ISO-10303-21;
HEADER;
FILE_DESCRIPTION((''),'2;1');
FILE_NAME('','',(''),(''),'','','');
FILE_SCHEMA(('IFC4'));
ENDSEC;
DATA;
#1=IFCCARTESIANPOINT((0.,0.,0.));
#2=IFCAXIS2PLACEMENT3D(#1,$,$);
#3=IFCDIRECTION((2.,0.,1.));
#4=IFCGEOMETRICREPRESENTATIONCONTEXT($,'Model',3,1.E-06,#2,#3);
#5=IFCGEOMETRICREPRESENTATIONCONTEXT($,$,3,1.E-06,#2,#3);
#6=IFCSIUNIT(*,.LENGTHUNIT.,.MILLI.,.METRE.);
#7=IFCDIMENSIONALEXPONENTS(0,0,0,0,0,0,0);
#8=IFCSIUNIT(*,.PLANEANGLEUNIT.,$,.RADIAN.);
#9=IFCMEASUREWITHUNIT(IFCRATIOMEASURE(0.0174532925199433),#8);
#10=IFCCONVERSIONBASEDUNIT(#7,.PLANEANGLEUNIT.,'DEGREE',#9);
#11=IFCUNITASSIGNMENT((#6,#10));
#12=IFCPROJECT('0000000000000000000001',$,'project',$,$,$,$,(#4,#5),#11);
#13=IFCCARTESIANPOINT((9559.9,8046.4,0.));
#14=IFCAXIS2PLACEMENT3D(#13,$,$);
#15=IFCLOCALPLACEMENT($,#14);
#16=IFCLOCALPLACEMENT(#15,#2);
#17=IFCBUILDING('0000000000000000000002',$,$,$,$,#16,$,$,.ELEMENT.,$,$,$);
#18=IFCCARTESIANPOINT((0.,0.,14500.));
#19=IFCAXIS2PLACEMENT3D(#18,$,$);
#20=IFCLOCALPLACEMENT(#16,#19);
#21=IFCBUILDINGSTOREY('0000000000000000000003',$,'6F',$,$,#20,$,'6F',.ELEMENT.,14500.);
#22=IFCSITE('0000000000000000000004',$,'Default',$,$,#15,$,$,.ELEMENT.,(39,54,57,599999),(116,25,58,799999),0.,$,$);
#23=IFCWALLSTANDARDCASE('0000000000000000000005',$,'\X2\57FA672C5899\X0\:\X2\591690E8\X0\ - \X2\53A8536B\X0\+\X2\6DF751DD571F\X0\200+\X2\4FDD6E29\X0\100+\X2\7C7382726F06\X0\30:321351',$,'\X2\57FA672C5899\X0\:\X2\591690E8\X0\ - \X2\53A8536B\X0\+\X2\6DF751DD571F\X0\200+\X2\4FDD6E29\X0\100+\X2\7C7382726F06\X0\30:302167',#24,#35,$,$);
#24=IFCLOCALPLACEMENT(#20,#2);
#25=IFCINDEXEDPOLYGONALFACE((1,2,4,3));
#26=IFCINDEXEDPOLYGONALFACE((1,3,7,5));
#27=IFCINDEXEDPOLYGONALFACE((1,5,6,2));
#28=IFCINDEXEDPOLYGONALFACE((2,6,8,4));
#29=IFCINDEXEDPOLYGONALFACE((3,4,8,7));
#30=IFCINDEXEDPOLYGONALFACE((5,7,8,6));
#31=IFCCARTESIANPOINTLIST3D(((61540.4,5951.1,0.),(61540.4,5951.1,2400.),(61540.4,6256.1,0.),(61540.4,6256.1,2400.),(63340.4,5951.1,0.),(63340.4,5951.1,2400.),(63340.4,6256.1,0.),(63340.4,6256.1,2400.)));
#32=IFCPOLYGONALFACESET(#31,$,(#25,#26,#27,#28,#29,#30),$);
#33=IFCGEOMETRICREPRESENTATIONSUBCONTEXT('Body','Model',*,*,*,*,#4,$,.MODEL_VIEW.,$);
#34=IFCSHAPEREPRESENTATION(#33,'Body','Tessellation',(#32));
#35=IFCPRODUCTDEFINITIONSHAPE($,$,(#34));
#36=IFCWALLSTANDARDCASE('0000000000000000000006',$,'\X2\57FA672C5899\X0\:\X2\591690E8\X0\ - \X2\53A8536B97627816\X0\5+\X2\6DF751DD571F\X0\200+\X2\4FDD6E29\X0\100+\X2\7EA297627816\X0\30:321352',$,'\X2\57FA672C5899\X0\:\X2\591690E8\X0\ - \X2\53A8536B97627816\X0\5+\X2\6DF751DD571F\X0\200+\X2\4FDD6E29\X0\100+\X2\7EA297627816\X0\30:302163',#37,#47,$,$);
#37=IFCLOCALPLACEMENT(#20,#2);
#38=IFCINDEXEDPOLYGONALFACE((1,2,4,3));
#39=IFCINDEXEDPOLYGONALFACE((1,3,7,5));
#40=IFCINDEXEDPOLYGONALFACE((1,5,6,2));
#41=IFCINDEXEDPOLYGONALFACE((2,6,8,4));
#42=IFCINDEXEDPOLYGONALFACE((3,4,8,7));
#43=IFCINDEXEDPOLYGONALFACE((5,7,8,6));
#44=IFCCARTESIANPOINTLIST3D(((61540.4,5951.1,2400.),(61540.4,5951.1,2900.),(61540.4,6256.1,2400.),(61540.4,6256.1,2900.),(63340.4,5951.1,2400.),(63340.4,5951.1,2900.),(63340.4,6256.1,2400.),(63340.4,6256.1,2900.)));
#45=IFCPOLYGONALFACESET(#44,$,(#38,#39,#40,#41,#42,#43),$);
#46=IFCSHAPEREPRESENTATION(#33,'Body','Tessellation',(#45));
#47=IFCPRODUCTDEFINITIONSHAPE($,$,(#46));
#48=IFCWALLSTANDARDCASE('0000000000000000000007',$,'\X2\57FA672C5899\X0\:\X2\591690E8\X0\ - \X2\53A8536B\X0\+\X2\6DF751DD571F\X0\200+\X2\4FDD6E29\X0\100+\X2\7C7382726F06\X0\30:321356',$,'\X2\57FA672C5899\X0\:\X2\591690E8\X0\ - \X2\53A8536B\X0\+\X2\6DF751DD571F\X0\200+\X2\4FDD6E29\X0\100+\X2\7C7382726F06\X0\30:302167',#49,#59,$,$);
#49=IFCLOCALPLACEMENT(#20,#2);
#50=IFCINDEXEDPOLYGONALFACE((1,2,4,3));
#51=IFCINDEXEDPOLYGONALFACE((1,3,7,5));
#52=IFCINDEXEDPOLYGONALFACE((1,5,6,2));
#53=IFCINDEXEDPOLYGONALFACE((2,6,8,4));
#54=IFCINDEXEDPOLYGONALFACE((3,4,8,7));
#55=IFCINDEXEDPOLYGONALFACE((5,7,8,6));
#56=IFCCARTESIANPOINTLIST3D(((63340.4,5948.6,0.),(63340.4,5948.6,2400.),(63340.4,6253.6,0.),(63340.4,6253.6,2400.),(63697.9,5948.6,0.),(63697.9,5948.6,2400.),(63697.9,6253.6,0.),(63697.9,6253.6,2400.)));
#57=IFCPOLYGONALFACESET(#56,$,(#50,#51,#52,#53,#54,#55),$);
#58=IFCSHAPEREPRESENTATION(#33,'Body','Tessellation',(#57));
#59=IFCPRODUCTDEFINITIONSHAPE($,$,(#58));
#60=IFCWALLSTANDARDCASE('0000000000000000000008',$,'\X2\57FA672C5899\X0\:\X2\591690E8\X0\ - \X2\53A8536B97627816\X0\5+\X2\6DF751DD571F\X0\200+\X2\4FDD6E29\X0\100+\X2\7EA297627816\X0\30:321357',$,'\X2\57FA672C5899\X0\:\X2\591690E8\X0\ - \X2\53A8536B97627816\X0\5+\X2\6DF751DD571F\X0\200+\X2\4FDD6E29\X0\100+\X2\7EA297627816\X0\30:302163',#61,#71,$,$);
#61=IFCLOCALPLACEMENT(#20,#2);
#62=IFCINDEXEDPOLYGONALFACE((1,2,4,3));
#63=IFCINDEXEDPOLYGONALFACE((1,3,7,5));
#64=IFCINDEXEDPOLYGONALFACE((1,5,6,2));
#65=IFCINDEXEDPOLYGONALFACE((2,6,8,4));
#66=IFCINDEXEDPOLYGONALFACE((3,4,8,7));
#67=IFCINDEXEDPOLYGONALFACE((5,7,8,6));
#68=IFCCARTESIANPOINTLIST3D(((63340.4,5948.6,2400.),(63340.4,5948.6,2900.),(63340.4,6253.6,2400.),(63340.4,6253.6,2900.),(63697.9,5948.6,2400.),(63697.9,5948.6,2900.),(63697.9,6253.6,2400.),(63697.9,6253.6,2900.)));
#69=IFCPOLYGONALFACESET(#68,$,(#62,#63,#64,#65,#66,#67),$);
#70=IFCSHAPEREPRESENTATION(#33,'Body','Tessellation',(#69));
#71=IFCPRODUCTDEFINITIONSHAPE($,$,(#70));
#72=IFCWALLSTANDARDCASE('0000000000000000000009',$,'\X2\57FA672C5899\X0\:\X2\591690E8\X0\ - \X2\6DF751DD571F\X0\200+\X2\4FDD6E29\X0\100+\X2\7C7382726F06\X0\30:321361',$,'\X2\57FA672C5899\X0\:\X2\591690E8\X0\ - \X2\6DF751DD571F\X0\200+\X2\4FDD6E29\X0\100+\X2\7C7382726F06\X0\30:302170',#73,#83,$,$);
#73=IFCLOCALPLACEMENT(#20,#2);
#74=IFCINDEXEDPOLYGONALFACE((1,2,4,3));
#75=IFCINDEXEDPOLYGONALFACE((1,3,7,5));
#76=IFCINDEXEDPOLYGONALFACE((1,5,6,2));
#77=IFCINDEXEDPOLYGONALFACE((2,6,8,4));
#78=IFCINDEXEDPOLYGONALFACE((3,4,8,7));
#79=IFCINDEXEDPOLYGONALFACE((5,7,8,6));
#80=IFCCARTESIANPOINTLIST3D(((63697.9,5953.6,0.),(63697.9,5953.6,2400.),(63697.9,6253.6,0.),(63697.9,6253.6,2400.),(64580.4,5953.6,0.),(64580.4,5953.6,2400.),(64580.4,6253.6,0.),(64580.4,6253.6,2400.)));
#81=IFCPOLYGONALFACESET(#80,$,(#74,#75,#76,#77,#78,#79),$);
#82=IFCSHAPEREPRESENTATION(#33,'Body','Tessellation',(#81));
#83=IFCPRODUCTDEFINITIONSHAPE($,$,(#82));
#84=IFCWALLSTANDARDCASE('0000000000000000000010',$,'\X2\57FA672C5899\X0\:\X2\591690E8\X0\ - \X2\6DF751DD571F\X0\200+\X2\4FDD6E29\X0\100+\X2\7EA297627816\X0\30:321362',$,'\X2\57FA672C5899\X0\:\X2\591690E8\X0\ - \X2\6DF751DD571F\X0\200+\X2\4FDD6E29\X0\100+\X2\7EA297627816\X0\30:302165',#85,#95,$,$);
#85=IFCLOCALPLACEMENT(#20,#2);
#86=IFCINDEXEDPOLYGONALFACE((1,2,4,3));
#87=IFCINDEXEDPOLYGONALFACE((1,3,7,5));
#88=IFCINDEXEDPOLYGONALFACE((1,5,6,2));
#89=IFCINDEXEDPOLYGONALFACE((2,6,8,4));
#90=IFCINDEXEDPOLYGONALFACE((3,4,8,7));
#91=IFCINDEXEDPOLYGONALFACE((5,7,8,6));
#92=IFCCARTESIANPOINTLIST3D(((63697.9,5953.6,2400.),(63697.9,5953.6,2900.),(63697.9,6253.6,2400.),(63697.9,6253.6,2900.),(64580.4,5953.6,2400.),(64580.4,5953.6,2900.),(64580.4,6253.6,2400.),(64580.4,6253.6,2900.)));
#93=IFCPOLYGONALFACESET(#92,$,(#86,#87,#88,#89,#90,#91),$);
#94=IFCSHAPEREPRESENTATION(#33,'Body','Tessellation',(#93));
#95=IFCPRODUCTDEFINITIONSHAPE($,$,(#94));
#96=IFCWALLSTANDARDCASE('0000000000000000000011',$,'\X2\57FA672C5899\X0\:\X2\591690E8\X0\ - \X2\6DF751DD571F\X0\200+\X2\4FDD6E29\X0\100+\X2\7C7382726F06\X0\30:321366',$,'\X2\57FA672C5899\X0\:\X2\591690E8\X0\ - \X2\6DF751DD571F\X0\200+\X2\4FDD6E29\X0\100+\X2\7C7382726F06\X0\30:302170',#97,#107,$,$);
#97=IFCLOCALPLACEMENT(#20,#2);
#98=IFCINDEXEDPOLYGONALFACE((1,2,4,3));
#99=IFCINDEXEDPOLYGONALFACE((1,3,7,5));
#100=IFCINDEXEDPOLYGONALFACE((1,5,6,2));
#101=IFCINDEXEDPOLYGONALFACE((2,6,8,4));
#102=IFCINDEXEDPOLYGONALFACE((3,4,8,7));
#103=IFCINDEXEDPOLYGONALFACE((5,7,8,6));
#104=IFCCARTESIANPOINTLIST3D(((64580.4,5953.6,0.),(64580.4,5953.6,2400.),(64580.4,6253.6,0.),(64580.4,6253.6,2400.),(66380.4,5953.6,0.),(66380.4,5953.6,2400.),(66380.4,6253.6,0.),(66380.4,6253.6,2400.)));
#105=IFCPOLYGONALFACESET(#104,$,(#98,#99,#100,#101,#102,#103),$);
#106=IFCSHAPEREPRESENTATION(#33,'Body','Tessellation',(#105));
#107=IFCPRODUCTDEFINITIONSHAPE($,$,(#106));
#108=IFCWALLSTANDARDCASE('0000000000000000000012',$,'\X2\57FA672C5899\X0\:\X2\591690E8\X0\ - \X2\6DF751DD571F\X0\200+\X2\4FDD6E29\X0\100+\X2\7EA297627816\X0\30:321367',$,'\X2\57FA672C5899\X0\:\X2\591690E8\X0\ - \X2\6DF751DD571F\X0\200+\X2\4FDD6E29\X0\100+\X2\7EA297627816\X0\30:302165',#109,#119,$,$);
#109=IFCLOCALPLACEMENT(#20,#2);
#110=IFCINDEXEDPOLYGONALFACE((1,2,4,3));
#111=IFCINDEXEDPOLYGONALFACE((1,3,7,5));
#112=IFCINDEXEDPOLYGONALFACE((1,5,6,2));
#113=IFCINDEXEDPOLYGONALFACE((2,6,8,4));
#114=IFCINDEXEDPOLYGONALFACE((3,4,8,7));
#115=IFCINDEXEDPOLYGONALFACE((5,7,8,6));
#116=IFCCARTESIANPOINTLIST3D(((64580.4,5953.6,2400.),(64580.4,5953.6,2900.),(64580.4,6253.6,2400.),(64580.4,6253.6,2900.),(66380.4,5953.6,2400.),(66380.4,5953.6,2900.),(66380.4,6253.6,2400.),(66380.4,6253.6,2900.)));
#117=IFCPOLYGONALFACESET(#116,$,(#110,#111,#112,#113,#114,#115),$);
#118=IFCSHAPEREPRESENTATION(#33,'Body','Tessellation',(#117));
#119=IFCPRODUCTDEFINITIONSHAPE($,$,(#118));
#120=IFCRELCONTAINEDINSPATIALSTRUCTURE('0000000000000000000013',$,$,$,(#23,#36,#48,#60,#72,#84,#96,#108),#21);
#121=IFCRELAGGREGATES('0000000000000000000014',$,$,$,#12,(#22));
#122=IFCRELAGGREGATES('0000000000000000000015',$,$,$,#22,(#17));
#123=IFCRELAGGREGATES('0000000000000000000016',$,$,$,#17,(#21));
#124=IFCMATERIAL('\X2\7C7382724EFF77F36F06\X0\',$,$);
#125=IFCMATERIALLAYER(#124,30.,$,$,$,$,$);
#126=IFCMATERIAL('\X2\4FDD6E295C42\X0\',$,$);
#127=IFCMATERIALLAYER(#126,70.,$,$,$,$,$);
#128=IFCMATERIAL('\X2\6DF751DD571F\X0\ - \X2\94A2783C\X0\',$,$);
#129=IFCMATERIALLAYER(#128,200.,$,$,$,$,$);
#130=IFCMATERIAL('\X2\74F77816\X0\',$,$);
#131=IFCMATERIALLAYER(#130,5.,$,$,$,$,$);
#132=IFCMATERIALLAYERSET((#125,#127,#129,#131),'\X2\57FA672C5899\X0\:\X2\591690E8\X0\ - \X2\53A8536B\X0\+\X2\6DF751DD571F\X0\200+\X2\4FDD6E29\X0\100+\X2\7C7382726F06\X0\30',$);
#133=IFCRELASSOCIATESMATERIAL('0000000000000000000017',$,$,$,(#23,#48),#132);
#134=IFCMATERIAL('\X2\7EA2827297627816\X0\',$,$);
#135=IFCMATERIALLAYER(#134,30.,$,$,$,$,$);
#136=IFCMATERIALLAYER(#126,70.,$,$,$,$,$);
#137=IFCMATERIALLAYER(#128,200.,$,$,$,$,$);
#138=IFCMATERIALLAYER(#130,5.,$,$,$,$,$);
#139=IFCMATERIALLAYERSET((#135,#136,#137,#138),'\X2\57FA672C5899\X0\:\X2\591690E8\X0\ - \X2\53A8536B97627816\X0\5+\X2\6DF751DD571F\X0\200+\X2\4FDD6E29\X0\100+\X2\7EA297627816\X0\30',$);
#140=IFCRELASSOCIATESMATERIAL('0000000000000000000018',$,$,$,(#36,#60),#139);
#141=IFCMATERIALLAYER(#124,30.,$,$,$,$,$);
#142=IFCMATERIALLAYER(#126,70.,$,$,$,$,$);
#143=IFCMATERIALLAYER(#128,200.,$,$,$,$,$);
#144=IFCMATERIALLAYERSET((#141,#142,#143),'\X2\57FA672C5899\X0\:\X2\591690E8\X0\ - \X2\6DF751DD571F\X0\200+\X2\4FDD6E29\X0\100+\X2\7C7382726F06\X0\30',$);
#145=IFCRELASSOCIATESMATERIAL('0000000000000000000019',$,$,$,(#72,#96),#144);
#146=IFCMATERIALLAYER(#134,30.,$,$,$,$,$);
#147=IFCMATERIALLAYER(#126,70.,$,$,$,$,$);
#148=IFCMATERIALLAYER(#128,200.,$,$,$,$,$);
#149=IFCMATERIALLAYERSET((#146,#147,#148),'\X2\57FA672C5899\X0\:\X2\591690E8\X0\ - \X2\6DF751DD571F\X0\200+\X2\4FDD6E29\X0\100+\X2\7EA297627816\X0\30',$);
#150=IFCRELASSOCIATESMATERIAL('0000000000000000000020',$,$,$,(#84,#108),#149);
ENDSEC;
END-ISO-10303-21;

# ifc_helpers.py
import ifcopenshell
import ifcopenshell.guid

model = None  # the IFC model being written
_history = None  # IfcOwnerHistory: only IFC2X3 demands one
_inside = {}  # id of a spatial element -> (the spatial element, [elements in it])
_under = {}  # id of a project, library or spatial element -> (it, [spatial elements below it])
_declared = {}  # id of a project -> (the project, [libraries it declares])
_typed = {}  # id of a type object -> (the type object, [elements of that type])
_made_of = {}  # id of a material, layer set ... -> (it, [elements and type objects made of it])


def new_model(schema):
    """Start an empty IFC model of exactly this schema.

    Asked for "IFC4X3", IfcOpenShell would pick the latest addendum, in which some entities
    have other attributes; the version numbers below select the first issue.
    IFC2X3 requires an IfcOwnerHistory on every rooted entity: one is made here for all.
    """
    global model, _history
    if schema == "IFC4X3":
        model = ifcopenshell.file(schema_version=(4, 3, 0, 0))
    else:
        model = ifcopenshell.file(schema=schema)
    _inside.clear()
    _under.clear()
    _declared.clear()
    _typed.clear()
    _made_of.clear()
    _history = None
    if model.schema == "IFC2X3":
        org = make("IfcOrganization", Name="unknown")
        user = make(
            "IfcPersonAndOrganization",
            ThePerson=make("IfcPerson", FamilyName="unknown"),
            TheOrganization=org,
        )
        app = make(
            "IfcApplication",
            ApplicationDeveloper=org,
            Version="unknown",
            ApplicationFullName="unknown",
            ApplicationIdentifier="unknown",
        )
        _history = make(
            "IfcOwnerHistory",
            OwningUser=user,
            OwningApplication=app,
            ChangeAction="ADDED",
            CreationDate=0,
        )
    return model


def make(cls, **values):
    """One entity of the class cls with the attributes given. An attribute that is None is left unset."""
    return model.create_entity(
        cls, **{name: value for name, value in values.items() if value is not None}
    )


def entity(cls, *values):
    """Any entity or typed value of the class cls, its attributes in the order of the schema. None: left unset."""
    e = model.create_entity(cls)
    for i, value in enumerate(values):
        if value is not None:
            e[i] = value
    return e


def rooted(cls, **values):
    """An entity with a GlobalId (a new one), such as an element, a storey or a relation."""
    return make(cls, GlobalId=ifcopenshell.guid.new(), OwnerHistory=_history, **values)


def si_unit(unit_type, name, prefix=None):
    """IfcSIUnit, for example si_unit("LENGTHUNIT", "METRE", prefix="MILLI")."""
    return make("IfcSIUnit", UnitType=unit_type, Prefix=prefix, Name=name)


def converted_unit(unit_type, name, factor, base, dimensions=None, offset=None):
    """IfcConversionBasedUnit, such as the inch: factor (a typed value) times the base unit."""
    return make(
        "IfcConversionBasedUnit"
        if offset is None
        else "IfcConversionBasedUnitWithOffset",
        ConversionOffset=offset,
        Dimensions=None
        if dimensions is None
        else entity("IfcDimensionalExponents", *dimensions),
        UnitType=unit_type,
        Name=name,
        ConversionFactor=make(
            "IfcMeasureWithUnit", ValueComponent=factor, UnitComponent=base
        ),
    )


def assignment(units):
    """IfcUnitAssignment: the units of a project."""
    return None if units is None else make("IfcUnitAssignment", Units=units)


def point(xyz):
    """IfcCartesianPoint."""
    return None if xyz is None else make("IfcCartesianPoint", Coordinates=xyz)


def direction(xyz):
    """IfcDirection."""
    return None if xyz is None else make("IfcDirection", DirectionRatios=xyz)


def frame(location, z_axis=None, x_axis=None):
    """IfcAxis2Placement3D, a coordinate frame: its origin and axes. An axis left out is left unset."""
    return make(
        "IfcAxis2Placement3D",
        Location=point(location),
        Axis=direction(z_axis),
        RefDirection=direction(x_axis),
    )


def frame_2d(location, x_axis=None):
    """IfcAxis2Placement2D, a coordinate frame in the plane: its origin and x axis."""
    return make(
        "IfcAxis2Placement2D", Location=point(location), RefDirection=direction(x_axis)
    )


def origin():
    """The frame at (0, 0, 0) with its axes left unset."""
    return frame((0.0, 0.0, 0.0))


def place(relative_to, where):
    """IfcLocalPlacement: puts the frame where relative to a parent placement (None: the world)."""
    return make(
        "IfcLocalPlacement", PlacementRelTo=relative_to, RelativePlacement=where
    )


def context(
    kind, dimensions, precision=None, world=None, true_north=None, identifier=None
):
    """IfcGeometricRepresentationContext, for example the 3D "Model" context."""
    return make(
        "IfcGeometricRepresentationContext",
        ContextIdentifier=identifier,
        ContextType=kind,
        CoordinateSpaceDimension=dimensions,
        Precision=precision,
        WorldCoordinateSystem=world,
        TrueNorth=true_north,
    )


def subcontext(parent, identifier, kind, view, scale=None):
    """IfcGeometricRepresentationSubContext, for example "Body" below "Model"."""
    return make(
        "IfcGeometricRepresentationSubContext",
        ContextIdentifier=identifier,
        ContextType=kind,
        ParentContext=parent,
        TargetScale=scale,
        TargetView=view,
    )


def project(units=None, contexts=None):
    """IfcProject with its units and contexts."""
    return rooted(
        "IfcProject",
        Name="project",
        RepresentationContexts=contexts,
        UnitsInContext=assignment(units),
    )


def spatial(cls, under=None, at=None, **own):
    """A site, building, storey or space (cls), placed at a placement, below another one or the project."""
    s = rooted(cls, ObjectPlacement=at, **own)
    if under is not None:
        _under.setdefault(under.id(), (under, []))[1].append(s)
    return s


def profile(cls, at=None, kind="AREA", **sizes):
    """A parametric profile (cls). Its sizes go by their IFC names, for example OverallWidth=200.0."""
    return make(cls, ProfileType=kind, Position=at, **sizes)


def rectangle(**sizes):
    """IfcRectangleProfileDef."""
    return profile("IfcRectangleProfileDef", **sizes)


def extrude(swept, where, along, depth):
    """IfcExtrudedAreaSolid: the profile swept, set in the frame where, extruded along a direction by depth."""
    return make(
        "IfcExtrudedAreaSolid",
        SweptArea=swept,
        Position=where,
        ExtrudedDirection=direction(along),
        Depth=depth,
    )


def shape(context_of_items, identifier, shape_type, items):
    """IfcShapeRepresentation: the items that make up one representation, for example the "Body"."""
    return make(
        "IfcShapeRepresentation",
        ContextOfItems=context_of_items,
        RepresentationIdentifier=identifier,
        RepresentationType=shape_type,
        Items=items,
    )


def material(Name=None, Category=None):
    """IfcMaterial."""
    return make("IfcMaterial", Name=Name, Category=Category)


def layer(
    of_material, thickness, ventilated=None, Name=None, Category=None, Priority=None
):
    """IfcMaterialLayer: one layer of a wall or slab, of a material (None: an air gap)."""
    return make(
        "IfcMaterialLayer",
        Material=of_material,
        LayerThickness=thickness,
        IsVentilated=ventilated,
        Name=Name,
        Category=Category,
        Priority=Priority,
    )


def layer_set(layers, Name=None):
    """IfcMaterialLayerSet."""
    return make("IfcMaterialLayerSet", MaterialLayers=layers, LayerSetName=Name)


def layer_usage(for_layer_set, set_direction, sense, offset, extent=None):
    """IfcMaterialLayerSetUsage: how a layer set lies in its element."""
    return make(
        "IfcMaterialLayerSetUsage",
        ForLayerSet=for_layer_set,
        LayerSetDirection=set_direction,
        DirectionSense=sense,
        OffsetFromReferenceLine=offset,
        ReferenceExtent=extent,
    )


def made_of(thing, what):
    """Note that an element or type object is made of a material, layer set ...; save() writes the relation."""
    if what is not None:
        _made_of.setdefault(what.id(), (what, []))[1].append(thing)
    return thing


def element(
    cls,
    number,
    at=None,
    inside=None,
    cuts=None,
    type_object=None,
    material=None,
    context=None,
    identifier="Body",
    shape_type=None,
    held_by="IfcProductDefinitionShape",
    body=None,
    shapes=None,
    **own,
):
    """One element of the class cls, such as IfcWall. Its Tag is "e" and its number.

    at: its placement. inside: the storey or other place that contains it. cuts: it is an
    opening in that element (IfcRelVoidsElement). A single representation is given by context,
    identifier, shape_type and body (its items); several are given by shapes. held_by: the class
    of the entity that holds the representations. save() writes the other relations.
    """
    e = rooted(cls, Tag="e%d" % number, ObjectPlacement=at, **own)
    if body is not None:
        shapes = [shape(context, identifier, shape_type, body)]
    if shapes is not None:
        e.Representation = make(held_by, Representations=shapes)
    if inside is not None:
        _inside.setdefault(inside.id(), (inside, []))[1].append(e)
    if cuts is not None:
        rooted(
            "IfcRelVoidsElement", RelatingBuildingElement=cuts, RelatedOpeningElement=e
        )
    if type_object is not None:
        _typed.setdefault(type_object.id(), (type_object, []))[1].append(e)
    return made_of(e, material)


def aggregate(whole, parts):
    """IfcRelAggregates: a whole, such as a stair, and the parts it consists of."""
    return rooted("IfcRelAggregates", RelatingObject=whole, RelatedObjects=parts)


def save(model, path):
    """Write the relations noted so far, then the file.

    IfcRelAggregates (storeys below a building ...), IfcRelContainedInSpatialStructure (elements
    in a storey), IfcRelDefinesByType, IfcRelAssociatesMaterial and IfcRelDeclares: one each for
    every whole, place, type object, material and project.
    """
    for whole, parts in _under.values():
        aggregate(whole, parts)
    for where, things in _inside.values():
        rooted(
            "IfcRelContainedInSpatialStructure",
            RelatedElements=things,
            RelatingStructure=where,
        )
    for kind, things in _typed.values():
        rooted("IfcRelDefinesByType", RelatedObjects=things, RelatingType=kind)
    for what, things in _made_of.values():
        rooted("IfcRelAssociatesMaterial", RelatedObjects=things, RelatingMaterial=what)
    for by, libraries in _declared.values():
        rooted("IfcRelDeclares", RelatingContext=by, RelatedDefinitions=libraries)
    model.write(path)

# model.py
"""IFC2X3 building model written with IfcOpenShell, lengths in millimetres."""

from ifc_helpers import new_model, entity, si_unit, converted_unit, direction, frame, frame_2d, origin, place, context, subcontext, project, spatial, rectangle, extrude, material, layer, layer_set, layer_usage, element, save


model = new_model("IFC2X3")

# Units and contexts
model_context = context("Model", 3, precision=1e-06, world=origin(), true_north=direction((2.0, 0.0, 1.0)))
context_of_model = context(None, 3, precision=1e-06, world=origin(), true_north=direction((2.0, 0.0, 1.0)))
body_context = subcontext(model_context, "Body", "Model", "MODEL_VIEW")
ifc_project = project(units=[si_unit("LENGTHUNIT", "METRE", prefix="MILLI"), converted_unit("PLANEANGLEUNIT", "DEGREE", entity("IfcRatioMeasure", 0.0174532925199433), si_unit("PLANEANGLEUNIT", "RADIAN"), dimensions=[0, 0, 0, 0, 0, 0, 0])], contexts=[model_context, context_of_model])

# Site, building, storey
site_placement = place(None, frame((9559.9, 8046.4, 0.0)))
site = spatial("IfcSite", under=ifc_project, at=site_placement, Name="Default", CompositionType="ELEMENT", RefLatitude=(39, 54, 57, 599999), RefLongitude=(116, 25, 58, 799999), RefElevation=0.0)
building_placement = place(site_placement, origin())
building = spatial("IfcBuilding", under=site, at=building_placement, CompositionType="ELEMENT")
storey_placement = place(building_placement, frame((0.0, 0.0, 14500.0)))
storey = spatial("IfcBuildingStorey", under=building, at=storey_placement, Name="6F", LongName="6F", CompositionType="ELEMENT", Elevation=14500.0)

# Shared definitions
ifc_material_1 = material(Name="红色面砖")
ifc_layer_1 = layer(ifc_material_1, 30.0)
ifc_material_2 = material(Name="保温层")
ifc_layer_2 = layer(ifc_material_2, 70.0)
ifc_material_3 = material(Name="混凝土 - 钢砼")
ifc_layer_3 = layer(ifc_material_3, 200.0)
ifc_layer_set_1 = layer_set([ifc_layer_1, ifc_layer_2, ifc_layer_3], Name="基本墙:外部 - 混凝土200+保温100+红面砖30")

# Shared definitions
ifc_material_4 = material(Name="瓷砖")

# Shared definitions
ifc_layer_4 = layer(ifc_material_1, 30.0)
ifc_layer_5 = layer(ifc_material_2, 70.0)
ifc_layer_6 = layer(ifc_material_3, 200.0)
ifc_layer_7 = layer(ifc_material_4, 5.0)
ifc_layer_set_2 = layer_set([ifc_layer_4, ifc_layer_5, ifc_layer_6, ifc_layer_7], Name="基本墙:外部 - 厨卫面砖5+混凝土200+保温100+红面砖30")

# Walls
ifc_material_5 = material(Name="米色仿石漆")
ifc_layer_8 = layer(ifc_material_5, 30.0)
ifc_layer_9 = layer(ifc_material_2, 70.0)
ifc_layer_10 = layer(ifc_material_3, 200.0)
ifc_layer_11 = layer(ifc_material_4, 5.0)
ifc_layer_set_3 = layer_set([ifc_layer_8, ifc_layer_9, ifc_layer_10, ifc_layer_11], Name="基本墙:外部 - 厨卫+混凝土200+保温100+米色漆30")
ifc_layer_usage_1 = layer_usage(ifc_layer_set_3, "AXIS2", "POSITIVE", -152.5)
wall_1_placement = place(storey_placement, frame((63340.4, 6103.6, 0.0), z_axis=(0.0, 0.0, 1.0), x_axis=(-1.0, 0.0, 0.0)))
element("IfcWallStandardCase", 1, at=wall_1_placement, inside=storey, material=ifc_layer_usage_1, Name="基本墙:外部 - 厨卫+混凝土200+保温100+米色漆30:321351", ObjectType="基本墙:外部 - 厨卫+混凝土200+保温100+米色漆30:302167", context=body_context, shape_type="SweptSolid", body=[
    extrude(rectangle(XDim=1800.0, YDim=305.0, at=frame_2d((900.0, 0.0), x_axis=(-1.0, 0.0))), origin(), (0.0, 0.0, 1.0), 2400.0),
])
ifc_layer_usage_2 = layer_usage(ifc_layer_set_2, "AXIS2", "POSITIVE", -152.5)
wall_2_placement = place(storey_placement, frame((63340.4, 6103.6, 2400.0), z_axis=(0.0, 0.0, 1.0), x_axis=(-1.0, 0.0, 0.0)))
element("IfcWallStandardCase", 2, at=wall_2_placement, inside=storey, material=ifc_layer_usage_2, Name="基本墙:外部 - 厨卫面砖5+混凝土200+保温100+红面砖30:321352", ObjectType="基本墙:外部 - 厨卫面砖5+混凝土200+保温100+红面砖30:302163", context=body_context, shape_type="SweptSolid", body=[
    extrude(rectangle(XDim=1800.0, YDim=305.0, at=frame_2d((900.0, 0.0), x_axis=(-1.0, 0.0))), origin(), (0.0, 0.0, 1.0), 500.0),
])
ifc_layer_usage_3 = layer_usage(ifc_layer_set_3, "AXIS2", "POSITIVE", -152.5)
wall_3_placement = place(storey_placement, frame((63697.9, 6101.1, 0.0), z_axis=(0.0, 0.0, 1.0), x_axis=(-1.0, 0.0, 0.0)))
element("IfcWallStandardCase", 3, at=wall_3_placement, inside=storey, material=ifc_layer_usage_3, Name="基本墙:外部 - 厨卫+混凝土200+保温100+米色漆30:321356", ObjectType="基本墙:外部 - 厨卫+混凝土200+保温100+米色漆30:302167", context=body_context, shape_type="SweptSolid", body=[
    extrude(rectangle(XDim=357.5, YDim=305.0, at=frame_2d((178.7, 0.0), x_axis=(-1.0, 0.0))), origin(), (0.0, 0.0, 1.0), 2400.0),
])
ifc_layer_usage_4 = layer_usage(ifc_layer_set_2, "AXIS2", "POSITIVE", -152.5)
wall_4_placement = place(storey_placement, frame((63697.9, 6101.1, 2400.0), z_axis=(0.0, 0.0, 1.0), x_axis=(-1.0, 0.0, 0.0)))
element("IfcWallStandardCase", 4, at=wall_4_placement, inside=storey, material=ifc_layer_usage_4, Name="基本墙:外部 - 厨卫面砖5+混凝土200+保温100+红面砖30:321357", ObjectType="基本墙:外部 - 厨卫面砖5+混凝土200+保温100+红面砖30:302163", context=body_context, shape_type="SweptSolid", body=[
    extrude(rectangle(XDim=357.5, YDim=305.0, at=frame_2d((178.7, 0.0), x_axis=(-1.0, 0.0))), origin(), (0.0, 0.0, 1.0), 500.0),
])
ifc_layer_12 = layer(ifc_material_5, 30.0)
ifc_layer_13 = layer(ifc_material_2, 70.0)
ifc_layer_14 = layer(ifc_material_3, 200.0)
ifc_layer_set_4 = layer_set([ifc_layer_12, ifc_layer_13, ifc_layer_14], Name="基本墙:外部 - 混凝土200+保温100+米色漆30")
ifc_layer_usage_5 = layer_usage(ifc_layer_set_4, "AXIS2", "POSITIVE", -150.0)
wall_5_placement = place(storey_placement, frame((64580.4, 6103.6, 0.0), z_axis=(0.0, 0.0, 1.0), x_axis=(-1.0, 0.0, 0.0)))
element("IfcWallStandardCase", 5, at=wall_5_placement, inside=storey, material=ifc_layer_usage_5, Name="基本墙:外部 - 混凝土200+保温100+米色漆30:321361", ObjectType="基本墙:外部 - 混凝土200+保温100+米色漆30:302170", context=body_context, shape_type="SweptSolid", body=[
    extrude(rectangle(XDim=882.5, YDim=300.0, at=frame_2d((441.2, 0.0), x_axis=(-1.0, 0.0))), origin(), (0.0, 0.0, 1.0), 2400.0),
])
ifc_layer_usage_6 = layer_usage(ifc_layer_set_1, "AXIS2", "POSITIVE", -150.0)
wall_6_placement = place(storey_placement, frame((64580.4, 6103.6, 2400.0), z_axis=(0.0, 0.0, 1.0), x_axis=(-1.0, 0.0, 0.0)))
element("IfcWallStandardCase", 6, at=wall_6_placement, inside=storey, material=ifc_layer_usage_6, Name="基本墙:外部 - 混凝土200+保温100+红面砖30:321362", ObjectType="基本墙:外部 - 混凝土200+保温100+红面砖30:302165", context=body_context, shape_type="SweptSolid", body=[
    extrude(rectangle(XDim=882.5, YDim=300.0, at=frame_2d((441.2, 0.0), x_axis=(-1.0, 0.0))), origin(), (0.0, 0.0, 1.0), 500.0),
])
ifc_layer_usage_7 = layer_usage(ifc_layer_set_4, "AXIS2", "POSITIVE", -150.0)
wall_7_placement = place(storey_placement, frame((66380.4, 6103.6, 0.0), z_axis=(0.0, 0.0, 1.0), x_axis=(-1.0, 0.0, 0.0)))
element("IfcWallStandardCase", 7, at=wall_7_placement, inside=storey, material=ifc_layer_usage_7, Name="基本墙:外部 - 混凝土200+保温100+米色漆30:321366", ObjectType="基本墙:外部 - 混凝土200+保温100+米色漆30:302170", context=body_context, shape_type="SweptSolid", body=[
    extrude(rectangle(XDim=1800.0, YDim=300.0, at=frame_2d((900.0, 0.0), x_axis=(-1.0, 0.0))), origin(), (0.0, 0.0, 1.0), 2400.0),
])
ifc_layer_usage_8 = layer_usage(ifc_layer_set_1, "AXIS2", "POSITIVE", -150.0)
wall_8_placement = place(storey_placement, frame((66380.4, 6103.6, 2400.0), z_axis=(0.0, 0.0, 1.0), x_axis=(-1.0, 0.0, 0.0)))
element("IfcWallStandardCase", 8, at=wall_8_placement, inside=storey, material=ifc_layer_usage_8, Name="基本墙:外部 - 混凝土200+保温100+红面砖30:321367", ObjectType="基本墙:外部 - 混凝土200+保温100+红面砖30:302165", context=body_context, shape_type="SweptSolid", body=[
    extrude(rectangle(XDim=1800.0, YDim=300.0, at=frame_2d((900.0, 0.0), x_axis=(-1.0, 0.0))), origin(), (0.0, 0.0, 1.0), 500.0),
])

save(model, "model.ifc")
